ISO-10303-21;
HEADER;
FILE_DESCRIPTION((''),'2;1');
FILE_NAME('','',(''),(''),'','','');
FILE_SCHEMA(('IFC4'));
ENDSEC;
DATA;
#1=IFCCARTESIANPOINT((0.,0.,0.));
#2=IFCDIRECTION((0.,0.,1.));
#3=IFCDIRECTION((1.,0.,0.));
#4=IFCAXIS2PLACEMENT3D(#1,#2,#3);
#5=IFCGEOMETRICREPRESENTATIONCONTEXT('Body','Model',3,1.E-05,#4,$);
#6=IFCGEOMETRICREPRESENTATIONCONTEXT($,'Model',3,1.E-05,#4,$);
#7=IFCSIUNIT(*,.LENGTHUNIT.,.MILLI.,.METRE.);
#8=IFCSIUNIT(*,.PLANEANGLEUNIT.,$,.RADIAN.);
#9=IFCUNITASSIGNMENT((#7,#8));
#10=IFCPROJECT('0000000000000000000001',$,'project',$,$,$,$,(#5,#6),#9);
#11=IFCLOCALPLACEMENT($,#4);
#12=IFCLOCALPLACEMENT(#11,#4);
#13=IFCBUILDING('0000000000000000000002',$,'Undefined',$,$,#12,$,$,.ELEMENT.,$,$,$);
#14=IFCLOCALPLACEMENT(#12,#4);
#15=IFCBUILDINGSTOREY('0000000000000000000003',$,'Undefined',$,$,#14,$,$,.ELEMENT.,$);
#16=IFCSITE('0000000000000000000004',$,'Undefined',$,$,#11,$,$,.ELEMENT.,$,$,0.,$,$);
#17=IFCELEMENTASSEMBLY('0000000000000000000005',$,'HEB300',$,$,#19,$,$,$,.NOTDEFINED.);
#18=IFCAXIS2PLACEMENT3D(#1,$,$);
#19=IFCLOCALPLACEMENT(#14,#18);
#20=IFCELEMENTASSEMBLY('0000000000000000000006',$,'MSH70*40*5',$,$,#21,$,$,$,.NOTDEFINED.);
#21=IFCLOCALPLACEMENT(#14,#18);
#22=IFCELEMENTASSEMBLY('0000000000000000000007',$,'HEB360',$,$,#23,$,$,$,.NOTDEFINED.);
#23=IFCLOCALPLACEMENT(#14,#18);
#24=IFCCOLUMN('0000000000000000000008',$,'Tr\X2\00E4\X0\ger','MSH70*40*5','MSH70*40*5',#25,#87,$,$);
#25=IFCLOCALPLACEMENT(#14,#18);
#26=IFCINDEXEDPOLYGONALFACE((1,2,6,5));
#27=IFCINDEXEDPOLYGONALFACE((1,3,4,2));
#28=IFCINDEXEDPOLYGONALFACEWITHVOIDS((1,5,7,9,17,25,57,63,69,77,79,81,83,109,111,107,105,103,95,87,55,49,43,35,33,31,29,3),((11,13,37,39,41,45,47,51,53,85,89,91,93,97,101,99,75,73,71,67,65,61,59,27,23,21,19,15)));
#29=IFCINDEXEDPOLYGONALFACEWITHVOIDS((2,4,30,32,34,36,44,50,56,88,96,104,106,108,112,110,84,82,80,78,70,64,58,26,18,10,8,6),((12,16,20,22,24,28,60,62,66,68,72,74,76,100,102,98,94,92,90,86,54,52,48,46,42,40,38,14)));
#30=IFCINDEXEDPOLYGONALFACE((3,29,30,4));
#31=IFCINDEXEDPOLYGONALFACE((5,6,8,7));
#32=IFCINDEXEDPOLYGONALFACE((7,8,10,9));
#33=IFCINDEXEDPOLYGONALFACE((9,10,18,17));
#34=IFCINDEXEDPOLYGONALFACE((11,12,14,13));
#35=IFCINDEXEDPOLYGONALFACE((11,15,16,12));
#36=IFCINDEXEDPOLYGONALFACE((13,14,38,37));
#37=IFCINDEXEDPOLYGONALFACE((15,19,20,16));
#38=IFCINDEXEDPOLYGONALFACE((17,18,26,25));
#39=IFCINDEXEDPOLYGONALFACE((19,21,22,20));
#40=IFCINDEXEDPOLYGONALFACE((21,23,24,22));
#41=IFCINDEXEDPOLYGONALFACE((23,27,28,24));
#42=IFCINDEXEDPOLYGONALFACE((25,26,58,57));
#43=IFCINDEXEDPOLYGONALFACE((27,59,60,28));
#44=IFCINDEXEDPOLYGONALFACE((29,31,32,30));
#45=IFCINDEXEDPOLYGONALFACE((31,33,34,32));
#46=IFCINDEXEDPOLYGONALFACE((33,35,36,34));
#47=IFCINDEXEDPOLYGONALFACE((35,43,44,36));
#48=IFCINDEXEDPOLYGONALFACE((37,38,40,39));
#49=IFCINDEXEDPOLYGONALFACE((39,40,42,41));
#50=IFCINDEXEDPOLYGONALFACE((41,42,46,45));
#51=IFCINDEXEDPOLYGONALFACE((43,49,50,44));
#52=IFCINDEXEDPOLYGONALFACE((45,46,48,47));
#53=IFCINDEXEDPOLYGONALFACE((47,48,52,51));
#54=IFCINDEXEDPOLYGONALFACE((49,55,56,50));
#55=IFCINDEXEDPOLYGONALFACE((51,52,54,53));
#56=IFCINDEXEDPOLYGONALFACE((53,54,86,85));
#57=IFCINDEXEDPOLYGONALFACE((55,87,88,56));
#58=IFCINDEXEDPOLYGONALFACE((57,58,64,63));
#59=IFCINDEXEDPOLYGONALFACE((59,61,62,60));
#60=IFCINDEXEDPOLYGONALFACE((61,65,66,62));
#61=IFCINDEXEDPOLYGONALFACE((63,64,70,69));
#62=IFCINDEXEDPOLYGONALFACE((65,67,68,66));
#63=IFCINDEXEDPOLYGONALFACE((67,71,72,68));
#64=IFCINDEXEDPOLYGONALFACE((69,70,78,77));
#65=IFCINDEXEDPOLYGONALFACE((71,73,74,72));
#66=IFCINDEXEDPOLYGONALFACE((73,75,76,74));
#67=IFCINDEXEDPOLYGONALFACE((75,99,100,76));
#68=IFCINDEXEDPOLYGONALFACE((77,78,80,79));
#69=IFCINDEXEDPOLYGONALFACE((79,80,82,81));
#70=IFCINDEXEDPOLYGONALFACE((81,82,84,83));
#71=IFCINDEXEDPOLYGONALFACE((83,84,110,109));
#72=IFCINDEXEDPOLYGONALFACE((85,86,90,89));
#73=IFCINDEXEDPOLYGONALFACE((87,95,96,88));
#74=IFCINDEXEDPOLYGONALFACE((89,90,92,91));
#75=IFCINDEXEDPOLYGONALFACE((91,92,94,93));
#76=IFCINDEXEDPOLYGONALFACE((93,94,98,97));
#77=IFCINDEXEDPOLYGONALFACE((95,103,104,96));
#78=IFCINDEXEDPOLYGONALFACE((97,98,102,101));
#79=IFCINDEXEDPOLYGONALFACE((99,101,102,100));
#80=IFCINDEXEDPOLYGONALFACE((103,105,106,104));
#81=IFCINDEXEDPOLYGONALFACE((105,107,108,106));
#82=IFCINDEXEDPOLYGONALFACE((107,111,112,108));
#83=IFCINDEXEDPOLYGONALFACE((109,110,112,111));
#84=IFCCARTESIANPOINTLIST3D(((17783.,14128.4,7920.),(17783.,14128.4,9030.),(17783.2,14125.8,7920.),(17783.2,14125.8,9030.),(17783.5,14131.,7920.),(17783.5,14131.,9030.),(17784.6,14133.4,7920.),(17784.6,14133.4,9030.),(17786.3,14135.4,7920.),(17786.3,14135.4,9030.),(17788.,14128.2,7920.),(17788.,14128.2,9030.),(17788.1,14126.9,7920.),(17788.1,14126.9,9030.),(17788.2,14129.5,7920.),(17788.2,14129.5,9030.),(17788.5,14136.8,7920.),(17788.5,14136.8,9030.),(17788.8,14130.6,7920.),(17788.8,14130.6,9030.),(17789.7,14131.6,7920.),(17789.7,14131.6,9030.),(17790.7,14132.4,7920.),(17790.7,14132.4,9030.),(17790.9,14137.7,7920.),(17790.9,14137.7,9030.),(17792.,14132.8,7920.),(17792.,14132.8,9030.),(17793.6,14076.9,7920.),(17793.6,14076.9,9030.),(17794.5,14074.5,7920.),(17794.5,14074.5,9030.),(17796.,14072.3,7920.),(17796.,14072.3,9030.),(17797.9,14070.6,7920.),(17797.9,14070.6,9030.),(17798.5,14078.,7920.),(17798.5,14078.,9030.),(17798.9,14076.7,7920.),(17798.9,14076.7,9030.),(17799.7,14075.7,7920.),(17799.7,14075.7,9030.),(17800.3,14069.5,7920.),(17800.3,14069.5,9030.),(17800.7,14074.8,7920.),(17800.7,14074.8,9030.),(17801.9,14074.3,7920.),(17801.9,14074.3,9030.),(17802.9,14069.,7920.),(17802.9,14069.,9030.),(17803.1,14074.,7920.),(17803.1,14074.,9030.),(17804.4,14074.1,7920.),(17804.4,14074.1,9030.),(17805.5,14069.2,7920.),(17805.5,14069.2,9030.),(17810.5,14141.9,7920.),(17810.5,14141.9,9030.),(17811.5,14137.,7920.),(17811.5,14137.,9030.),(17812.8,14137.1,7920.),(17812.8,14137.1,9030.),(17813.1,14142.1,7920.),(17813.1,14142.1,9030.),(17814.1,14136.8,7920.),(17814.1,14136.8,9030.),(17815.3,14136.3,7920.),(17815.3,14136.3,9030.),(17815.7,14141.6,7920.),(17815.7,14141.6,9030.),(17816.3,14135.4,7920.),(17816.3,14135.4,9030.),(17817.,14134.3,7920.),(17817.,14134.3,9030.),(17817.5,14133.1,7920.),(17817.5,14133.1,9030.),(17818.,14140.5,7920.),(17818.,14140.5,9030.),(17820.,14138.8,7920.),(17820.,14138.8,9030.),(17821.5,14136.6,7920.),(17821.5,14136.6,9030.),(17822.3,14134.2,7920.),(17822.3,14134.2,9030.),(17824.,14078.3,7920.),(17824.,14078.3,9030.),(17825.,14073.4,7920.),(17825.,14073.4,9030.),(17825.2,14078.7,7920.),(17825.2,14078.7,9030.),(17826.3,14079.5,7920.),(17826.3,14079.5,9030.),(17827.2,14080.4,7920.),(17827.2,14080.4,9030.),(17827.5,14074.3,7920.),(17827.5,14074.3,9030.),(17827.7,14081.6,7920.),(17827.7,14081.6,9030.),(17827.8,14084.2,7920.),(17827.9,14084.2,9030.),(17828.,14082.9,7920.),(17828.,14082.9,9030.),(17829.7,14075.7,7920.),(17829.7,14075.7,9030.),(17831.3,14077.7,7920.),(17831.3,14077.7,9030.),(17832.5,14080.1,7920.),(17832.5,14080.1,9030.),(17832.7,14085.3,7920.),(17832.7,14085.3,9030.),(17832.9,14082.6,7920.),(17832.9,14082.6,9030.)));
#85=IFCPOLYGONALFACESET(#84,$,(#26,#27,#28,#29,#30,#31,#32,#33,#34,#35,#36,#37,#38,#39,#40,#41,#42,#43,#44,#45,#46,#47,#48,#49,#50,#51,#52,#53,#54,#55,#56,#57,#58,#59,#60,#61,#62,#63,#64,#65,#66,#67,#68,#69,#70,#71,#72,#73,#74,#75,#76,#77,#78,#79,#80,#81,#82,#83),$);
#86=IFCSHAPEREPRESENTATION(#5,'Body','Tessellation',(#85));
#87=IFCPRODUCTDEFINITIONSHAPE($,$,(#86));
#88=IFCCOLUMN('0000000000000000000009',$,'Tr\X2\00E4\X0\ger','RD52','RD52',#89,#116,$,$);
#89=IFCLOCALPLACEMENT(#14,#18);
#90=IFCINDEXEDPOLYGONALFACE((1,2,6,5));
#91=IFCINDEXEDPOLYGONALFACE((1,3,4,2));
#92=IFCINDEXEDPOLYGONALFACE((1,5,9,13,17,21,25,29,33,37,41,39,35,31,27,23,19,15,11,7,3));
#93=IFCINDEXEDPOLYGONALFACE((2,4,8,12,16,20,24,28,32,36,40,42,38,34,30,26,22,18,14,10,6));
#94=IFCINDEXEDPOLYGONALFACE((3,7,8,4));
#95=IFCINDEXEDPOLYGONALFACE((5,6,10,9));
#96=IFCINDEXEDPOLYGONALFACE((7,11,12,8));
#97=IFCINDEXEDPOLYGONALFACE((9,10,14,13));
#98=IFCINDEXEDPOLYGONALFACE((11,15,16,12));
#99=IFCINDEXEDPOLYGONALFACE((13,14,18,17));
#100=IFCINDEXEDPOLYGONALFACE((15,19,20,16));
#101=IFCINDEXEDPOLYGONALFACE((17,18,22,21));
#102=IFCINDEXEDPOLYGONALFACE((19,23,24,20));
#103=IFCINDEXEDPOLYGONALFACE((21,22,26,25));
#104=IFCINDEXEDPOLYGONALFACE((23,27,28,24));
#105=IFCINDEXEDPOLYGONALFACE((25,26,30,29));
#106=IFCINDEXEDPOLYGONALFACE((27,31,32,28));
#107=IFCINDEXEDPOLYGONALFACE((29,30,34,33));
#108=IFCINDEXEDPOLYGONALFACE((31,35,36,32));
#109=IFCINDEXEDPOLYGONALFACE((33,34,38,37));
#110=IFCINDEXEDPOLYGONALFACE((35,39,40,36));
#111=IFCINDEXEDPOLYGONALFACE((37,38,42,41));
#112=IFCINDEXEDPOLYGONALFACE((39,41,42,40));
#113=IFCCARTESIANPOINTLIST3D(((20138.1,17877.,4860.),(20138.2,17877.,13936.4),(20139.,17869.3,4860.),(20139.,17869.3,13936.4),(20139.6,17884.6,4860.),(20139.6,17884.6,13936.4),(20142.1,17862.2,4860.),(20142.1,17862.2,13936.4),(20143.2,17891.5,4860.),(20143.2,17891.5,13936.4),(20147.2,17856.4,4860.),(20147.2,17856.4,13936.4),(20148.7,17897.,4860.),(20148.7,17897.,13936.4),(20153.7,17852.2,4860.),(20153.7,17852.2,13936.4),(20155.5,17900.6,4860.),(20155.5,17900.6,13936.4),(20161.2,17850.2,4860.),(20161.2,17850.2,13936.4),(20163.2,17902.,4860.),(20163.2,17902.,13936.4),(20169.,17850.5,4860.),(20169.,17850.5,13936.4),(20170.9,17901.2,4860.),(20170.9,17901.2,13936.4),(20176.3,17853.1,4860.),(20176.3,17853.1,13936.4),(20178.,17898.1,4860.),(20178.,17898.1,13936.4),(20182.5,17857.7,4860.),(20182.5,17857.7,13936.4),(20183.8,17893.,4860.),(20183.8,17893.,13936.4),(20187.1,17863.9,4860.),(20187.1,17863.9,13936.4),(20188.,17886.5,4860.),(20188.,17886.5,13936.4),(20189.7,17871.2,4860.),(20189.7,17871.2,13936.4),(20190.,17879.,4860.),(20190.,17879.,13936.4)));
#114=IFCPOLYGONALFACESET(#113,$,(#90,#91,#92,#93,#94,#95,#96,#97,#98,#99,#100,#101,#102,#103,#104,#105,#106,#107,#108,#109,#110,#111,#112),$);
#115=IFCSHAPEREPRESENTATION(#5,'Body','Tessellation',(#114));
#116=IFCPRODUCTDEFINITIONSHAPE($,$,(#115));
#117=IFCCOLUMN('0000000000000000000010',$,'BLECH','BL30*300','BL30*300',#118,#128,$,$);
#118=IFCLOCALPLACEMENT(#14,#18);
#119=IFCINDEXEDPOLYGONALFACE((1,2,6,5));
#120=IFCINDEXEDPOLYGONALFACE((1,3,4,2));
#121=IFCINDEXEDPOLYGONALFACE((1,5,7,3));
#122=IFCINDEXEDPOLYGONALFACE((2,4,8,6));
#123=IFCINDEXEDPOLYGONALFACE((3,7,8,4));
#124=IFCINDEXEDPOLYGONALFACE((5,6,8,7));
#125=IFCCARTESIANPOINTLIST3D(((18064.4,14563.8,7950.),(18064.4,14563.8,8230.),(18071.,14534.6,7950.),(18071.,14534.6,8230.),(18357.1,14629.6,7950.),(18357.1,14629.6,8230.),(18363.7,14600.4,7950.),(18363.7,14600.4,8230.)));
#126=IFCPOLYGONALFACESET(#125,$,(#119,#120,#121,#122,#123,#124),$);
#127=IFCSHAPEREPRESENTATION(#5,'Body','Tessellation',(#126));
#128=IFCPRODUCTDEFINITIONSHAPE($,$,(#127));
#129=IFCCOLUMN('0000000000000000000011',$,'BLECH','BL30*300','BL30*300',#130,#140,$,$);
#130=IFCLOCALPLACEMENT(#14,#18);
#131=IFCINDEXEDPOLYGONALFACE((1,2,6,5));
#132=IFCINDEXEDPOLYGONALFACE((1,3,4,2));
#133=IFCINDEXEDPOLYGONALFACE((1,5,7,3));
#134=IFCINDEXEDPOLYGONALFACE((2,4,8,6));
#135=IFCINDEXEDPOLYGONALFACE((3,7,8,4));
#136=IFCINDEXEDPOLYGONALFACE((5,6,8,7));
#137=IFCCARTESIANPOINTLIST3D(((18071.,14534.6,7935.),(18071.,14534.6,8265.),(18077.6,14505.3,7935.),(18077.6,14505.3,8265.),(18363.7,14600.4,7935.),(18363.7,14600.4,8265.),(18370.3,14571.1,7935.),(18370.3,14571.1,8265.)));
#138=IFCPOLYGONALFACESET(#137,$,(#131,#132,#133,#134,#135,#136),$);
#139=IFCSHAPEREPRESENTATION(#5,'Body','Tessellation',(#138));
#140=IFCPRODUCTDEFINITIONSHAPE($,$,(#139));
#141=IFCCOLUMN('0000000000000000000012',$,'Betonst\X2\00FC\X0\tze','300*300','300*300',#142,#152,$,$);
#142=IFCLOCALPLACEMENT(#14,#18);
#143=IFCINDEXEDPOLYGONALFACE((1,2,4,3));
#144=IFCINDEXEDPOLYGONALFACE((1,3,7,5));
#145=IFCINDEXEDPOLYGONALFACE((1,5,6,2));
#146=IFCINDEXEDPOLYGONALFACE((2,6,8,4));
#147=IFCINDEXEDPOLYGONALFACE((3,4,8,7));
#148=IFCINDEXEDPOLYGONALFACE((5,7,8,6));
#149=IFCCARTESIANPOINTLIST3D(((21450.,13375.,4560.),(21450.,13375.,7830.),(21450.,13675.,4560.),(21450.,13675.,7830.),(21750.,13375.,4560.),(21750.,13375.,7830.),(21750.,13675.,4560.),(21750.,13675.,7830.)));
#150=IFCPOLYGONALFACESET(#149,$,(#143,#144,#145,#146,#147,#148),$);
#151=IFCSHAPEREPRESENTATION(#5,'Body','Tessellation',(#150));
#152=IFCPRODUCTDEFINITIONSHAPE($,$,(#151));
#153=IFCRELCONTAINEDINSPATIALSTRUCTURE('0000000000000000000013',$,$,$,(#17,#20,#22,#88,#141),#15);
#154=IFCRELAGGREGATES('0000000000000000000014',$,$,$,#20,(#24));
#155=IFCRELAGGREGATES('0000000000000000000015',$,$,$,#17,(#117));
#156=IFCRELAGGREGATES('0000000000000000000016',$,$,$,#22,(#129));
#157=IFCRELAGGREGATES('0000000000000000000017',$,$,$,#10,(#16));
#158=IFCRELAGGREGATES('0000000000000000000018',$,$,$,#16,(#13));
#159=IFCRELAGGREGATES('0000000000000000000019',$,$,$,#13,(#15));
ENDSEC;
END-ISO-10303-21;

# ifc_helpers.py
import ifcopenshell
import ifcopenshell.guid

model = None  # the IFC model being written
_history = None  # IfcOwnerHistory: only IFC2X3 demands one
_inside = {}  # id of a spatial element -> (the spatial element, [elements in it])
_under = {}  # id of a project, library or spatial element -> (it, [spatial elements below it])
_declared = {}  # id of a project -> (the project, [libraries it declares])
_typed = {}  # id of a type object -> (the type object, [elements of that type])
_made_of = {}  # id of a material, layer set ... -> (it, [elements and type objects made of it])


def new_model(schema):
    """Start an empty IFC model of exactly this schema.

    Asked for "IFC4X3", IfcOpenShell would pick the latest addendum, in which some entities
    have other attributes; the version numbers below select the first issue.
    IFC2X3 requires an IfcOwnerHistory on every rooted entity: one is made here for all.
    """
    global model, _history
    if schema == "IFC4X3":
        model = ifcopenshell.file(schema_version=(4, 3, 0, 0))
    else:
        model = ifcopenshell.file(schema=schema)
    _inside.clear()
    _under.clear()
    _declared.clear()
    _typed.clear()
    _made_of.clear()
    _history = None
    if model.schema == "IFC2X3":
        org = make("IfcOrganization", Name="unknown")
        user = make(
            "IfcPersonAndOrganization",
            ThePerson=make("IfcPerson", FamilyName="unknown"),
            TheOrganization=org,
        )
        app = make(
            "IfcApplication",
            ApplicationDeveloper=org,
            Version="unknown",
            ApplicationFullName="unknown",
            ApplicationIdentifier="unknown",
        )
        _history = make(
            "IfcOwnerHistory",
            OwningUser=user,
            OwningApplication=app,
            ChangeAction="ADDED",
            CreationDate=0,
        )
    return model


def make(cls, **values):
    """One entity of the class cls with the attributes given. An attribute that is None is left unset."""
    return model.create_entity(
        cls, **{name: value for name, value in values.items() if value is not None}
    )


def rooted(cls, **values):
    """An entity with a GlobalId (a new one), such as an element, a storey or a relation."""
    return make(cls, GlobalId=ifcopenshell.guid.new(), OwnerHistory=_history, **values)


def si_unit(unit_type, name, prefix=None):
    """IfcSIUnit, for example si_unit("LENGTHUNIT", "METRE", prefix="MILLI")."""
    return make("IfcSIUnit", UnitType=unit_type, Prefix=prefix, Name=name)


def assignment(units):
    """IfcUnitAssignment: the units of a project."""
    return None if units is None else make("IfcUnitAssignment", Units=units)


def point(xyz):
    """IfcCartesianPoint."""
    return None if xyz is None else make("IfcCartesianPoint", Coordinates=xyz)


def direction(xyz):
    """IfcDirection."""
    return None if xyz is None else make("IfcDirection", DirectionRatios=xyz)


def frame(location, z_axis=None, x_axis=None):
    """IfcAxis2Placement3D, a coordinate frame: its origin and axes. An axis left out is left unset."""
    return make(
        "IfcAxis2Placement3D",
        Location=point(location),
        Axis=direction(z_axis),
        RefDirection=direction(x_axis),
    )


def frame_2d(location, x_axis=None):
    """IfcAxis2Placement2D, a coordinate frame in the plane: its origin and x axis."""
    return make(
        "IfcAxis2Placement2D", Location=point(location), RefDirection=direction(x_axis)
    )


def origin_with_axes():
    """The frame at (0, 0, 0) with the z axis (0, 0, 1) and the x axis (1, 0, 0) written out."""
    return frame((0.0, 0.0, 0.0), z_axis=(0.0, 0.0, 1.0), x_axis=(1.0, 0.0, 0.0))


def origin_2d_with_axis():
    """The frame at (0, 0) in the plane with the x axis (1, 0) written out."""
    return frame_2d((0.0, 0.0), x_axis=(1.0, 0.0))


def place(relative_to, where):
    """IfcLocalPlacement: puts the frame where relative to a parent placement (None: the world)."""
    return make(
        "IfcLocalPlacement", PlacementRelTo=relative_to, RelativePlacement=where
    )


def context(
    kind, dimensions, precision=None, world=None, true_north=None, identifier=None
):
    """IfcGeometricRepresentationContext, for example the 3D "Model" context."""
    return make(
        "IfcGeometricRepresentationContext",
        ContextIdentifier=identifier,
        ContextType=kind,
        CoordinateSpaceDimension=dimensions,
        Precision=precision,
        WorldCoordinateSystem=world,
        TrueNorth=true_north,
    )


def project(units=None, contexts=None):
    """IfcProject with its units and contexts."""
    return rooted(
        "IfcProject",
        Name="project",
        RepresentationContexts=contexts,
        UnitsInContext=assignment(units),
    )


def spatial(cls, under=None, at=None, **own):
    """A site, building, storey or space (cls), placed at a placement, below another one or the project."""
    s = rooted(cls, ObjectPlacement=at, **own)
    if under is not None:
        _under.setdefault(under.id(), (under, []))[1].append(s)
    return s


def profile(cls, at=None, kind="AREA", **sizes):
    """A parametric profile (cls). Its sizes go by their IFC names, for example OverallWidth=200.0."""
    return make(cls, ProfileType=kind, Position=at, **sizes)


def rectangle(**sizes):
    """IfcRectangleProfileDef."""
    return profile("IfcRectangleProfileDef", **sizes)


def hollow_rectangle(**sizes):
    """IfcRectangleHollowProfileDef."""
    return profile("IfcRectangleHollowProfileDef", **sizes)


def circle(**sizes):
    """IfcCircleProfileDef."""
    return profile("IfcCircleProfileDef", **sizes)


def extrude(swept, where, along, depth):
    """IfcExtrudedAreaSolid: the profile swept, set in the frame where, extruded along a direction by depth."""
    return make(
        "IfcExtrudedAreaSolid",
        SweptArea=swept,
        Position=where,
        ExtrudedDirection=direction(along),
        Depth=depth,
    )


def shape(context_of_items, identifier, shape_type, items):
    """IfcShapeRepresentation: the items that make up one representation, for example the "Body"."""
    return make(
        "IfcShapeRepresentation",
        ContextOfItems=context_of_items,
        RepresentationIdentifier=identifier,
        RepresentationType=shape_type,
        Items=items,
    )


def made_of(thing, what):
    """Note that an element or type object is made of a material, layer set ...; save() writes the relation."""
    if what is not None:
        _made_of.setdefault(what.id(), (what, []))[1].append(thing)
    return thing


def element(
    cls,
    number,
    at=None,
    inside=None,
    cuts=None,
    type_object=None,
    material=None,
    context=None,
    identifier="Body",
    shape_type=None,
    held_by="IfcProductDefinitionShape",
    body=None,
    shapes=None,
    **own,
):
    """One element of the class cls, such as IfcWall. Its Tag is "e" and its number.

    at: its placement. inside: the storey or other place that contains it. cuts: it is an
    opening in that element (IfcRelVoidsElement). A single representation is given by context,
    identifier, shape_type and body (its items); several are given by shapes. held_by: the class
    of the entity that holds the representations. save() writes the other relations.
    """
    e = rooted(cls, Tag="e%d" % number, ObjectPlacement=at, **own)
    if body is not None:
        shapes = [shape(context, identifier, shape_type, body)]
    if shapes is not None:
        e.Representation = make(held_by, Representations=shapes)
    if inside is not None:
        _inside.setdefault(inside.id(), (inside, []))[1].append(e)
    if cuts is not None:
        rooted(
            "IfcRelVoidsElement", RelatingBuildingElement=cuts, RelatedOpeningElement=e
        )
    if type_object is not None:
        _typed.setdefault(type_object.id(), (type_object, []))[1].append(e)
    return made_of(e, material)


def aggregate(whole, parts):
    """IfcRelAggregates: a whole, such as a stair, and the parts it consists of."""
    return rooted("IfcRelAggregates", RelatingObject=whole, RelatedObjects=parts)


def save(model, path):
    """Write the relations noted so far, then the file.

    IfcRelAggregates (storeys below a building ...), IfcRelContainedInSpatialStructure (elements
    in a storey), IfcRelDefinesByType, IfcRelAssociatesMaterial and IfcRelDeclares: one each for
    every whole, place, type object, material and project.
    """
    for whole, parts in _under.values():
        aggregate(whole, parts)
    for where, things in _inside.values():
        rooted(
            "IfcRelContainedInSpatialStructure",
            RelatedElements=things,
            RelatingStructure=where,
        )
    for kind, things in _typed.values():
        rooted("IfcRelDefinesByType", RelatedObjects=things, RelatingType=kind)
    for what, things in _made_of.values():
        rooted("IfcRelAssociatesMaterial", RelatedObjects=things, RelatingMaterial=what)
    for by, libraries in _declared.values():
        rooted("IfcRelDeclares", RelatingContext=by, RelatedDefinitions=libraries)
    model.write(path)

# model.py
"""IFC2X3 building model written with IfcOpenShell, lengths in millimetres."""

from ifc_helpers import new_model, si_unit, frame, origin_with_axes, origin_2d_with_axis, place, context, project, spatial, rectangle, hollow_rectangle, circle, extrude, element, aggregate, save


model = new_model("IFC2X3")

# Units and contexts
model_context_1 = context("Model", 3, precision=1e-05, world=origin_with_axes(), identifier="Body")
model_context_2 = context("Model", 3, precision=1e-05, world=origin_with_axes())
ifc_project = project(units=[si_unit("LENGTHUNIT", "METRE", prefix="MILLI"), si_unit("PLANEANGLEUNIT", "RADIAN")], contexts=[model_context_1, model_context_2])

# Site, building, storey
site_placement = place(None, origin_with_axes())
site = spatial("IfcSite", under=ifc_project, at=site_placement, Name="Undefined", CompositionType="ELEMENT", RefElevation=0.0)
building_placement = place(site_placement, origin_with_axes())
building = spatial("IfcBuilding", under=site, at=building_placement, Name="Undefined", CompositionType="ELEMENT")
storey_placement = place(building_placement, origin_with_axes())
storey = spatial("IfcBuildingStorey", under=building, at=storey_placement, Name="Undefined", CompositionType="ELEMENT")

# Element assembly
assembly_1 = element("IfcElementAssembly", 1, inside=storey, Name="HEB300", PredefinedType="NOTDEFINED")

# Element assembly
assembly_2 = element("IfcElementAssembly", 2, inside=storey, Name="MSH70*40*5", PredefinedType="NOTDEFINED")

# Element assembly
assembly_3 = element("IfcElementAssembly", 3, inside=storey, Name="HEB360", PredefinedType="NOTDEFINED")

# Columns
column_1_placement = place(storey_placement, frame((17808.0, 14105.5, 7920.0), z_axis=(0.0, 0.0, 1.0), x_axis=(1.0, 0.0, 0.0)))
column_1 = element("IfcColumn", 4, at=column_1_placement, Name="Träger", Description="MSH70*40*5", ObjectType="MSH70*40*5", context=model_context_1, shape_type="SweptSolid", body=[
    extrude(hollow_rectangle(XDim=40.0, YDim=70.0, WallThickness=5.0, InnerFilletRadius=5.0, OuterFilletRadius=10.0, at=origin_2d_with_axis()), frame((0.0, 0.0, 1110.0), z_axis=(0.0, 0.0, -1.0), x_axis=(-0.978148, -0.207912, 0.000005)), (0.0, 0.0, 1.0), 1110.0),
])
aggregate(assembly_2, [column_1])
column_2_placement = place(storey_placement, frame((20164.1, 17876.1, 4860.0), z_axis=(0.0, 0.0, 1.0), x_axis=(1.0, 0.0, 0.0)))
element("IfcColumn", 5, at=column_2_placement, inside=storey, Name="Träger", Description="RD52", ObjectType="RD52", context=model_context_1, shape_type="SweptSolid", body=[
    extrude(circle(Radius=26.0, at=origin_2d_with_axis()), frame((0.0, 0.0, 9076.4), z_axis=(0.0, 0.0, -1.0), x_axis=(0.707105, -0.707108, 0.0)), (0.0, 0.0, 1.0), 9076.4),
])
column_3_placement = place(storey_placement, frame((18214.0, 14582.1, 7950.0), z_axis=(0.0, 0.0, 1.0), x_axis=(1.0, 0.0, 0.0)))
column_3 = element("IfcColumn", 6, at=column_3_placement, Name="BLECH", Description="BL30*300", ObjectType="BL30*300", context=model_context_1, shape_type="SweptSolid", body=[
    extrude(rectangle(XDim=30.0, YDim=300.0, at=origin_2d_with_axis()), frame((0.0, 0.0, 280.0), z_axis=(0.0, 0.0, -1.0), x_axis=(-0.21934, 0.975649, 0.0)), (0.0, 0.0, 1.0), 280.0),
])
aggregate(assembly_1, [column_3])
column_4_placement = place(storey_placement, frame((18220.6, 14552.8, 7935.0), z_axis=(0.0, 0.0, 1.0), x_axis=(1.0, 0.0, 0.0)))
column_4 = element("IfcColumn", 7, at=column_4_placement, Name="BLECH", Description="BL30*300", ObjectType="BL30*300", context=model_context_1, shape_type="SweptSolid", body=[
    extrude(rectangle(XDim=30.0, YDim=300.0, at=origin_2d_with_axis()), frame((0.0, 0.0, 330.0), z_axis=(0.0, 0.0, -1.0), x_axis=(-0.21934, 0.975649, 0.0)), (0.0, 0.0, 1.0), 330.0),
])
aggregate(assembly_3, [column_4])
column_5_placement = place(storey_placement, frame((21600.0, 13525.0, 4560.0), z_axis=(0.0, 0.0, 1.0), x_axis=(1.0, 0.0, 0.0)))
element("IfcColumn", 8, at=column_5_placement, inside=storey, Name="Betonstütze", Description="300*300", ObjectType="300*300", context=model_context_1, shape_type="SweptSolid", body=[
    extrude(rectangle(XDim=300.0, YDim=300.0, at=origin_2d_with_axis()), frame((0.0, 0.0, 3270.0), z_axis=(0.0, 0.0, -1.0), x_axis=(1.0, 0.0, 0.0)), (0.0, 0.0, 1.0), 3270.0),
])

save(model, "model.ifc")
